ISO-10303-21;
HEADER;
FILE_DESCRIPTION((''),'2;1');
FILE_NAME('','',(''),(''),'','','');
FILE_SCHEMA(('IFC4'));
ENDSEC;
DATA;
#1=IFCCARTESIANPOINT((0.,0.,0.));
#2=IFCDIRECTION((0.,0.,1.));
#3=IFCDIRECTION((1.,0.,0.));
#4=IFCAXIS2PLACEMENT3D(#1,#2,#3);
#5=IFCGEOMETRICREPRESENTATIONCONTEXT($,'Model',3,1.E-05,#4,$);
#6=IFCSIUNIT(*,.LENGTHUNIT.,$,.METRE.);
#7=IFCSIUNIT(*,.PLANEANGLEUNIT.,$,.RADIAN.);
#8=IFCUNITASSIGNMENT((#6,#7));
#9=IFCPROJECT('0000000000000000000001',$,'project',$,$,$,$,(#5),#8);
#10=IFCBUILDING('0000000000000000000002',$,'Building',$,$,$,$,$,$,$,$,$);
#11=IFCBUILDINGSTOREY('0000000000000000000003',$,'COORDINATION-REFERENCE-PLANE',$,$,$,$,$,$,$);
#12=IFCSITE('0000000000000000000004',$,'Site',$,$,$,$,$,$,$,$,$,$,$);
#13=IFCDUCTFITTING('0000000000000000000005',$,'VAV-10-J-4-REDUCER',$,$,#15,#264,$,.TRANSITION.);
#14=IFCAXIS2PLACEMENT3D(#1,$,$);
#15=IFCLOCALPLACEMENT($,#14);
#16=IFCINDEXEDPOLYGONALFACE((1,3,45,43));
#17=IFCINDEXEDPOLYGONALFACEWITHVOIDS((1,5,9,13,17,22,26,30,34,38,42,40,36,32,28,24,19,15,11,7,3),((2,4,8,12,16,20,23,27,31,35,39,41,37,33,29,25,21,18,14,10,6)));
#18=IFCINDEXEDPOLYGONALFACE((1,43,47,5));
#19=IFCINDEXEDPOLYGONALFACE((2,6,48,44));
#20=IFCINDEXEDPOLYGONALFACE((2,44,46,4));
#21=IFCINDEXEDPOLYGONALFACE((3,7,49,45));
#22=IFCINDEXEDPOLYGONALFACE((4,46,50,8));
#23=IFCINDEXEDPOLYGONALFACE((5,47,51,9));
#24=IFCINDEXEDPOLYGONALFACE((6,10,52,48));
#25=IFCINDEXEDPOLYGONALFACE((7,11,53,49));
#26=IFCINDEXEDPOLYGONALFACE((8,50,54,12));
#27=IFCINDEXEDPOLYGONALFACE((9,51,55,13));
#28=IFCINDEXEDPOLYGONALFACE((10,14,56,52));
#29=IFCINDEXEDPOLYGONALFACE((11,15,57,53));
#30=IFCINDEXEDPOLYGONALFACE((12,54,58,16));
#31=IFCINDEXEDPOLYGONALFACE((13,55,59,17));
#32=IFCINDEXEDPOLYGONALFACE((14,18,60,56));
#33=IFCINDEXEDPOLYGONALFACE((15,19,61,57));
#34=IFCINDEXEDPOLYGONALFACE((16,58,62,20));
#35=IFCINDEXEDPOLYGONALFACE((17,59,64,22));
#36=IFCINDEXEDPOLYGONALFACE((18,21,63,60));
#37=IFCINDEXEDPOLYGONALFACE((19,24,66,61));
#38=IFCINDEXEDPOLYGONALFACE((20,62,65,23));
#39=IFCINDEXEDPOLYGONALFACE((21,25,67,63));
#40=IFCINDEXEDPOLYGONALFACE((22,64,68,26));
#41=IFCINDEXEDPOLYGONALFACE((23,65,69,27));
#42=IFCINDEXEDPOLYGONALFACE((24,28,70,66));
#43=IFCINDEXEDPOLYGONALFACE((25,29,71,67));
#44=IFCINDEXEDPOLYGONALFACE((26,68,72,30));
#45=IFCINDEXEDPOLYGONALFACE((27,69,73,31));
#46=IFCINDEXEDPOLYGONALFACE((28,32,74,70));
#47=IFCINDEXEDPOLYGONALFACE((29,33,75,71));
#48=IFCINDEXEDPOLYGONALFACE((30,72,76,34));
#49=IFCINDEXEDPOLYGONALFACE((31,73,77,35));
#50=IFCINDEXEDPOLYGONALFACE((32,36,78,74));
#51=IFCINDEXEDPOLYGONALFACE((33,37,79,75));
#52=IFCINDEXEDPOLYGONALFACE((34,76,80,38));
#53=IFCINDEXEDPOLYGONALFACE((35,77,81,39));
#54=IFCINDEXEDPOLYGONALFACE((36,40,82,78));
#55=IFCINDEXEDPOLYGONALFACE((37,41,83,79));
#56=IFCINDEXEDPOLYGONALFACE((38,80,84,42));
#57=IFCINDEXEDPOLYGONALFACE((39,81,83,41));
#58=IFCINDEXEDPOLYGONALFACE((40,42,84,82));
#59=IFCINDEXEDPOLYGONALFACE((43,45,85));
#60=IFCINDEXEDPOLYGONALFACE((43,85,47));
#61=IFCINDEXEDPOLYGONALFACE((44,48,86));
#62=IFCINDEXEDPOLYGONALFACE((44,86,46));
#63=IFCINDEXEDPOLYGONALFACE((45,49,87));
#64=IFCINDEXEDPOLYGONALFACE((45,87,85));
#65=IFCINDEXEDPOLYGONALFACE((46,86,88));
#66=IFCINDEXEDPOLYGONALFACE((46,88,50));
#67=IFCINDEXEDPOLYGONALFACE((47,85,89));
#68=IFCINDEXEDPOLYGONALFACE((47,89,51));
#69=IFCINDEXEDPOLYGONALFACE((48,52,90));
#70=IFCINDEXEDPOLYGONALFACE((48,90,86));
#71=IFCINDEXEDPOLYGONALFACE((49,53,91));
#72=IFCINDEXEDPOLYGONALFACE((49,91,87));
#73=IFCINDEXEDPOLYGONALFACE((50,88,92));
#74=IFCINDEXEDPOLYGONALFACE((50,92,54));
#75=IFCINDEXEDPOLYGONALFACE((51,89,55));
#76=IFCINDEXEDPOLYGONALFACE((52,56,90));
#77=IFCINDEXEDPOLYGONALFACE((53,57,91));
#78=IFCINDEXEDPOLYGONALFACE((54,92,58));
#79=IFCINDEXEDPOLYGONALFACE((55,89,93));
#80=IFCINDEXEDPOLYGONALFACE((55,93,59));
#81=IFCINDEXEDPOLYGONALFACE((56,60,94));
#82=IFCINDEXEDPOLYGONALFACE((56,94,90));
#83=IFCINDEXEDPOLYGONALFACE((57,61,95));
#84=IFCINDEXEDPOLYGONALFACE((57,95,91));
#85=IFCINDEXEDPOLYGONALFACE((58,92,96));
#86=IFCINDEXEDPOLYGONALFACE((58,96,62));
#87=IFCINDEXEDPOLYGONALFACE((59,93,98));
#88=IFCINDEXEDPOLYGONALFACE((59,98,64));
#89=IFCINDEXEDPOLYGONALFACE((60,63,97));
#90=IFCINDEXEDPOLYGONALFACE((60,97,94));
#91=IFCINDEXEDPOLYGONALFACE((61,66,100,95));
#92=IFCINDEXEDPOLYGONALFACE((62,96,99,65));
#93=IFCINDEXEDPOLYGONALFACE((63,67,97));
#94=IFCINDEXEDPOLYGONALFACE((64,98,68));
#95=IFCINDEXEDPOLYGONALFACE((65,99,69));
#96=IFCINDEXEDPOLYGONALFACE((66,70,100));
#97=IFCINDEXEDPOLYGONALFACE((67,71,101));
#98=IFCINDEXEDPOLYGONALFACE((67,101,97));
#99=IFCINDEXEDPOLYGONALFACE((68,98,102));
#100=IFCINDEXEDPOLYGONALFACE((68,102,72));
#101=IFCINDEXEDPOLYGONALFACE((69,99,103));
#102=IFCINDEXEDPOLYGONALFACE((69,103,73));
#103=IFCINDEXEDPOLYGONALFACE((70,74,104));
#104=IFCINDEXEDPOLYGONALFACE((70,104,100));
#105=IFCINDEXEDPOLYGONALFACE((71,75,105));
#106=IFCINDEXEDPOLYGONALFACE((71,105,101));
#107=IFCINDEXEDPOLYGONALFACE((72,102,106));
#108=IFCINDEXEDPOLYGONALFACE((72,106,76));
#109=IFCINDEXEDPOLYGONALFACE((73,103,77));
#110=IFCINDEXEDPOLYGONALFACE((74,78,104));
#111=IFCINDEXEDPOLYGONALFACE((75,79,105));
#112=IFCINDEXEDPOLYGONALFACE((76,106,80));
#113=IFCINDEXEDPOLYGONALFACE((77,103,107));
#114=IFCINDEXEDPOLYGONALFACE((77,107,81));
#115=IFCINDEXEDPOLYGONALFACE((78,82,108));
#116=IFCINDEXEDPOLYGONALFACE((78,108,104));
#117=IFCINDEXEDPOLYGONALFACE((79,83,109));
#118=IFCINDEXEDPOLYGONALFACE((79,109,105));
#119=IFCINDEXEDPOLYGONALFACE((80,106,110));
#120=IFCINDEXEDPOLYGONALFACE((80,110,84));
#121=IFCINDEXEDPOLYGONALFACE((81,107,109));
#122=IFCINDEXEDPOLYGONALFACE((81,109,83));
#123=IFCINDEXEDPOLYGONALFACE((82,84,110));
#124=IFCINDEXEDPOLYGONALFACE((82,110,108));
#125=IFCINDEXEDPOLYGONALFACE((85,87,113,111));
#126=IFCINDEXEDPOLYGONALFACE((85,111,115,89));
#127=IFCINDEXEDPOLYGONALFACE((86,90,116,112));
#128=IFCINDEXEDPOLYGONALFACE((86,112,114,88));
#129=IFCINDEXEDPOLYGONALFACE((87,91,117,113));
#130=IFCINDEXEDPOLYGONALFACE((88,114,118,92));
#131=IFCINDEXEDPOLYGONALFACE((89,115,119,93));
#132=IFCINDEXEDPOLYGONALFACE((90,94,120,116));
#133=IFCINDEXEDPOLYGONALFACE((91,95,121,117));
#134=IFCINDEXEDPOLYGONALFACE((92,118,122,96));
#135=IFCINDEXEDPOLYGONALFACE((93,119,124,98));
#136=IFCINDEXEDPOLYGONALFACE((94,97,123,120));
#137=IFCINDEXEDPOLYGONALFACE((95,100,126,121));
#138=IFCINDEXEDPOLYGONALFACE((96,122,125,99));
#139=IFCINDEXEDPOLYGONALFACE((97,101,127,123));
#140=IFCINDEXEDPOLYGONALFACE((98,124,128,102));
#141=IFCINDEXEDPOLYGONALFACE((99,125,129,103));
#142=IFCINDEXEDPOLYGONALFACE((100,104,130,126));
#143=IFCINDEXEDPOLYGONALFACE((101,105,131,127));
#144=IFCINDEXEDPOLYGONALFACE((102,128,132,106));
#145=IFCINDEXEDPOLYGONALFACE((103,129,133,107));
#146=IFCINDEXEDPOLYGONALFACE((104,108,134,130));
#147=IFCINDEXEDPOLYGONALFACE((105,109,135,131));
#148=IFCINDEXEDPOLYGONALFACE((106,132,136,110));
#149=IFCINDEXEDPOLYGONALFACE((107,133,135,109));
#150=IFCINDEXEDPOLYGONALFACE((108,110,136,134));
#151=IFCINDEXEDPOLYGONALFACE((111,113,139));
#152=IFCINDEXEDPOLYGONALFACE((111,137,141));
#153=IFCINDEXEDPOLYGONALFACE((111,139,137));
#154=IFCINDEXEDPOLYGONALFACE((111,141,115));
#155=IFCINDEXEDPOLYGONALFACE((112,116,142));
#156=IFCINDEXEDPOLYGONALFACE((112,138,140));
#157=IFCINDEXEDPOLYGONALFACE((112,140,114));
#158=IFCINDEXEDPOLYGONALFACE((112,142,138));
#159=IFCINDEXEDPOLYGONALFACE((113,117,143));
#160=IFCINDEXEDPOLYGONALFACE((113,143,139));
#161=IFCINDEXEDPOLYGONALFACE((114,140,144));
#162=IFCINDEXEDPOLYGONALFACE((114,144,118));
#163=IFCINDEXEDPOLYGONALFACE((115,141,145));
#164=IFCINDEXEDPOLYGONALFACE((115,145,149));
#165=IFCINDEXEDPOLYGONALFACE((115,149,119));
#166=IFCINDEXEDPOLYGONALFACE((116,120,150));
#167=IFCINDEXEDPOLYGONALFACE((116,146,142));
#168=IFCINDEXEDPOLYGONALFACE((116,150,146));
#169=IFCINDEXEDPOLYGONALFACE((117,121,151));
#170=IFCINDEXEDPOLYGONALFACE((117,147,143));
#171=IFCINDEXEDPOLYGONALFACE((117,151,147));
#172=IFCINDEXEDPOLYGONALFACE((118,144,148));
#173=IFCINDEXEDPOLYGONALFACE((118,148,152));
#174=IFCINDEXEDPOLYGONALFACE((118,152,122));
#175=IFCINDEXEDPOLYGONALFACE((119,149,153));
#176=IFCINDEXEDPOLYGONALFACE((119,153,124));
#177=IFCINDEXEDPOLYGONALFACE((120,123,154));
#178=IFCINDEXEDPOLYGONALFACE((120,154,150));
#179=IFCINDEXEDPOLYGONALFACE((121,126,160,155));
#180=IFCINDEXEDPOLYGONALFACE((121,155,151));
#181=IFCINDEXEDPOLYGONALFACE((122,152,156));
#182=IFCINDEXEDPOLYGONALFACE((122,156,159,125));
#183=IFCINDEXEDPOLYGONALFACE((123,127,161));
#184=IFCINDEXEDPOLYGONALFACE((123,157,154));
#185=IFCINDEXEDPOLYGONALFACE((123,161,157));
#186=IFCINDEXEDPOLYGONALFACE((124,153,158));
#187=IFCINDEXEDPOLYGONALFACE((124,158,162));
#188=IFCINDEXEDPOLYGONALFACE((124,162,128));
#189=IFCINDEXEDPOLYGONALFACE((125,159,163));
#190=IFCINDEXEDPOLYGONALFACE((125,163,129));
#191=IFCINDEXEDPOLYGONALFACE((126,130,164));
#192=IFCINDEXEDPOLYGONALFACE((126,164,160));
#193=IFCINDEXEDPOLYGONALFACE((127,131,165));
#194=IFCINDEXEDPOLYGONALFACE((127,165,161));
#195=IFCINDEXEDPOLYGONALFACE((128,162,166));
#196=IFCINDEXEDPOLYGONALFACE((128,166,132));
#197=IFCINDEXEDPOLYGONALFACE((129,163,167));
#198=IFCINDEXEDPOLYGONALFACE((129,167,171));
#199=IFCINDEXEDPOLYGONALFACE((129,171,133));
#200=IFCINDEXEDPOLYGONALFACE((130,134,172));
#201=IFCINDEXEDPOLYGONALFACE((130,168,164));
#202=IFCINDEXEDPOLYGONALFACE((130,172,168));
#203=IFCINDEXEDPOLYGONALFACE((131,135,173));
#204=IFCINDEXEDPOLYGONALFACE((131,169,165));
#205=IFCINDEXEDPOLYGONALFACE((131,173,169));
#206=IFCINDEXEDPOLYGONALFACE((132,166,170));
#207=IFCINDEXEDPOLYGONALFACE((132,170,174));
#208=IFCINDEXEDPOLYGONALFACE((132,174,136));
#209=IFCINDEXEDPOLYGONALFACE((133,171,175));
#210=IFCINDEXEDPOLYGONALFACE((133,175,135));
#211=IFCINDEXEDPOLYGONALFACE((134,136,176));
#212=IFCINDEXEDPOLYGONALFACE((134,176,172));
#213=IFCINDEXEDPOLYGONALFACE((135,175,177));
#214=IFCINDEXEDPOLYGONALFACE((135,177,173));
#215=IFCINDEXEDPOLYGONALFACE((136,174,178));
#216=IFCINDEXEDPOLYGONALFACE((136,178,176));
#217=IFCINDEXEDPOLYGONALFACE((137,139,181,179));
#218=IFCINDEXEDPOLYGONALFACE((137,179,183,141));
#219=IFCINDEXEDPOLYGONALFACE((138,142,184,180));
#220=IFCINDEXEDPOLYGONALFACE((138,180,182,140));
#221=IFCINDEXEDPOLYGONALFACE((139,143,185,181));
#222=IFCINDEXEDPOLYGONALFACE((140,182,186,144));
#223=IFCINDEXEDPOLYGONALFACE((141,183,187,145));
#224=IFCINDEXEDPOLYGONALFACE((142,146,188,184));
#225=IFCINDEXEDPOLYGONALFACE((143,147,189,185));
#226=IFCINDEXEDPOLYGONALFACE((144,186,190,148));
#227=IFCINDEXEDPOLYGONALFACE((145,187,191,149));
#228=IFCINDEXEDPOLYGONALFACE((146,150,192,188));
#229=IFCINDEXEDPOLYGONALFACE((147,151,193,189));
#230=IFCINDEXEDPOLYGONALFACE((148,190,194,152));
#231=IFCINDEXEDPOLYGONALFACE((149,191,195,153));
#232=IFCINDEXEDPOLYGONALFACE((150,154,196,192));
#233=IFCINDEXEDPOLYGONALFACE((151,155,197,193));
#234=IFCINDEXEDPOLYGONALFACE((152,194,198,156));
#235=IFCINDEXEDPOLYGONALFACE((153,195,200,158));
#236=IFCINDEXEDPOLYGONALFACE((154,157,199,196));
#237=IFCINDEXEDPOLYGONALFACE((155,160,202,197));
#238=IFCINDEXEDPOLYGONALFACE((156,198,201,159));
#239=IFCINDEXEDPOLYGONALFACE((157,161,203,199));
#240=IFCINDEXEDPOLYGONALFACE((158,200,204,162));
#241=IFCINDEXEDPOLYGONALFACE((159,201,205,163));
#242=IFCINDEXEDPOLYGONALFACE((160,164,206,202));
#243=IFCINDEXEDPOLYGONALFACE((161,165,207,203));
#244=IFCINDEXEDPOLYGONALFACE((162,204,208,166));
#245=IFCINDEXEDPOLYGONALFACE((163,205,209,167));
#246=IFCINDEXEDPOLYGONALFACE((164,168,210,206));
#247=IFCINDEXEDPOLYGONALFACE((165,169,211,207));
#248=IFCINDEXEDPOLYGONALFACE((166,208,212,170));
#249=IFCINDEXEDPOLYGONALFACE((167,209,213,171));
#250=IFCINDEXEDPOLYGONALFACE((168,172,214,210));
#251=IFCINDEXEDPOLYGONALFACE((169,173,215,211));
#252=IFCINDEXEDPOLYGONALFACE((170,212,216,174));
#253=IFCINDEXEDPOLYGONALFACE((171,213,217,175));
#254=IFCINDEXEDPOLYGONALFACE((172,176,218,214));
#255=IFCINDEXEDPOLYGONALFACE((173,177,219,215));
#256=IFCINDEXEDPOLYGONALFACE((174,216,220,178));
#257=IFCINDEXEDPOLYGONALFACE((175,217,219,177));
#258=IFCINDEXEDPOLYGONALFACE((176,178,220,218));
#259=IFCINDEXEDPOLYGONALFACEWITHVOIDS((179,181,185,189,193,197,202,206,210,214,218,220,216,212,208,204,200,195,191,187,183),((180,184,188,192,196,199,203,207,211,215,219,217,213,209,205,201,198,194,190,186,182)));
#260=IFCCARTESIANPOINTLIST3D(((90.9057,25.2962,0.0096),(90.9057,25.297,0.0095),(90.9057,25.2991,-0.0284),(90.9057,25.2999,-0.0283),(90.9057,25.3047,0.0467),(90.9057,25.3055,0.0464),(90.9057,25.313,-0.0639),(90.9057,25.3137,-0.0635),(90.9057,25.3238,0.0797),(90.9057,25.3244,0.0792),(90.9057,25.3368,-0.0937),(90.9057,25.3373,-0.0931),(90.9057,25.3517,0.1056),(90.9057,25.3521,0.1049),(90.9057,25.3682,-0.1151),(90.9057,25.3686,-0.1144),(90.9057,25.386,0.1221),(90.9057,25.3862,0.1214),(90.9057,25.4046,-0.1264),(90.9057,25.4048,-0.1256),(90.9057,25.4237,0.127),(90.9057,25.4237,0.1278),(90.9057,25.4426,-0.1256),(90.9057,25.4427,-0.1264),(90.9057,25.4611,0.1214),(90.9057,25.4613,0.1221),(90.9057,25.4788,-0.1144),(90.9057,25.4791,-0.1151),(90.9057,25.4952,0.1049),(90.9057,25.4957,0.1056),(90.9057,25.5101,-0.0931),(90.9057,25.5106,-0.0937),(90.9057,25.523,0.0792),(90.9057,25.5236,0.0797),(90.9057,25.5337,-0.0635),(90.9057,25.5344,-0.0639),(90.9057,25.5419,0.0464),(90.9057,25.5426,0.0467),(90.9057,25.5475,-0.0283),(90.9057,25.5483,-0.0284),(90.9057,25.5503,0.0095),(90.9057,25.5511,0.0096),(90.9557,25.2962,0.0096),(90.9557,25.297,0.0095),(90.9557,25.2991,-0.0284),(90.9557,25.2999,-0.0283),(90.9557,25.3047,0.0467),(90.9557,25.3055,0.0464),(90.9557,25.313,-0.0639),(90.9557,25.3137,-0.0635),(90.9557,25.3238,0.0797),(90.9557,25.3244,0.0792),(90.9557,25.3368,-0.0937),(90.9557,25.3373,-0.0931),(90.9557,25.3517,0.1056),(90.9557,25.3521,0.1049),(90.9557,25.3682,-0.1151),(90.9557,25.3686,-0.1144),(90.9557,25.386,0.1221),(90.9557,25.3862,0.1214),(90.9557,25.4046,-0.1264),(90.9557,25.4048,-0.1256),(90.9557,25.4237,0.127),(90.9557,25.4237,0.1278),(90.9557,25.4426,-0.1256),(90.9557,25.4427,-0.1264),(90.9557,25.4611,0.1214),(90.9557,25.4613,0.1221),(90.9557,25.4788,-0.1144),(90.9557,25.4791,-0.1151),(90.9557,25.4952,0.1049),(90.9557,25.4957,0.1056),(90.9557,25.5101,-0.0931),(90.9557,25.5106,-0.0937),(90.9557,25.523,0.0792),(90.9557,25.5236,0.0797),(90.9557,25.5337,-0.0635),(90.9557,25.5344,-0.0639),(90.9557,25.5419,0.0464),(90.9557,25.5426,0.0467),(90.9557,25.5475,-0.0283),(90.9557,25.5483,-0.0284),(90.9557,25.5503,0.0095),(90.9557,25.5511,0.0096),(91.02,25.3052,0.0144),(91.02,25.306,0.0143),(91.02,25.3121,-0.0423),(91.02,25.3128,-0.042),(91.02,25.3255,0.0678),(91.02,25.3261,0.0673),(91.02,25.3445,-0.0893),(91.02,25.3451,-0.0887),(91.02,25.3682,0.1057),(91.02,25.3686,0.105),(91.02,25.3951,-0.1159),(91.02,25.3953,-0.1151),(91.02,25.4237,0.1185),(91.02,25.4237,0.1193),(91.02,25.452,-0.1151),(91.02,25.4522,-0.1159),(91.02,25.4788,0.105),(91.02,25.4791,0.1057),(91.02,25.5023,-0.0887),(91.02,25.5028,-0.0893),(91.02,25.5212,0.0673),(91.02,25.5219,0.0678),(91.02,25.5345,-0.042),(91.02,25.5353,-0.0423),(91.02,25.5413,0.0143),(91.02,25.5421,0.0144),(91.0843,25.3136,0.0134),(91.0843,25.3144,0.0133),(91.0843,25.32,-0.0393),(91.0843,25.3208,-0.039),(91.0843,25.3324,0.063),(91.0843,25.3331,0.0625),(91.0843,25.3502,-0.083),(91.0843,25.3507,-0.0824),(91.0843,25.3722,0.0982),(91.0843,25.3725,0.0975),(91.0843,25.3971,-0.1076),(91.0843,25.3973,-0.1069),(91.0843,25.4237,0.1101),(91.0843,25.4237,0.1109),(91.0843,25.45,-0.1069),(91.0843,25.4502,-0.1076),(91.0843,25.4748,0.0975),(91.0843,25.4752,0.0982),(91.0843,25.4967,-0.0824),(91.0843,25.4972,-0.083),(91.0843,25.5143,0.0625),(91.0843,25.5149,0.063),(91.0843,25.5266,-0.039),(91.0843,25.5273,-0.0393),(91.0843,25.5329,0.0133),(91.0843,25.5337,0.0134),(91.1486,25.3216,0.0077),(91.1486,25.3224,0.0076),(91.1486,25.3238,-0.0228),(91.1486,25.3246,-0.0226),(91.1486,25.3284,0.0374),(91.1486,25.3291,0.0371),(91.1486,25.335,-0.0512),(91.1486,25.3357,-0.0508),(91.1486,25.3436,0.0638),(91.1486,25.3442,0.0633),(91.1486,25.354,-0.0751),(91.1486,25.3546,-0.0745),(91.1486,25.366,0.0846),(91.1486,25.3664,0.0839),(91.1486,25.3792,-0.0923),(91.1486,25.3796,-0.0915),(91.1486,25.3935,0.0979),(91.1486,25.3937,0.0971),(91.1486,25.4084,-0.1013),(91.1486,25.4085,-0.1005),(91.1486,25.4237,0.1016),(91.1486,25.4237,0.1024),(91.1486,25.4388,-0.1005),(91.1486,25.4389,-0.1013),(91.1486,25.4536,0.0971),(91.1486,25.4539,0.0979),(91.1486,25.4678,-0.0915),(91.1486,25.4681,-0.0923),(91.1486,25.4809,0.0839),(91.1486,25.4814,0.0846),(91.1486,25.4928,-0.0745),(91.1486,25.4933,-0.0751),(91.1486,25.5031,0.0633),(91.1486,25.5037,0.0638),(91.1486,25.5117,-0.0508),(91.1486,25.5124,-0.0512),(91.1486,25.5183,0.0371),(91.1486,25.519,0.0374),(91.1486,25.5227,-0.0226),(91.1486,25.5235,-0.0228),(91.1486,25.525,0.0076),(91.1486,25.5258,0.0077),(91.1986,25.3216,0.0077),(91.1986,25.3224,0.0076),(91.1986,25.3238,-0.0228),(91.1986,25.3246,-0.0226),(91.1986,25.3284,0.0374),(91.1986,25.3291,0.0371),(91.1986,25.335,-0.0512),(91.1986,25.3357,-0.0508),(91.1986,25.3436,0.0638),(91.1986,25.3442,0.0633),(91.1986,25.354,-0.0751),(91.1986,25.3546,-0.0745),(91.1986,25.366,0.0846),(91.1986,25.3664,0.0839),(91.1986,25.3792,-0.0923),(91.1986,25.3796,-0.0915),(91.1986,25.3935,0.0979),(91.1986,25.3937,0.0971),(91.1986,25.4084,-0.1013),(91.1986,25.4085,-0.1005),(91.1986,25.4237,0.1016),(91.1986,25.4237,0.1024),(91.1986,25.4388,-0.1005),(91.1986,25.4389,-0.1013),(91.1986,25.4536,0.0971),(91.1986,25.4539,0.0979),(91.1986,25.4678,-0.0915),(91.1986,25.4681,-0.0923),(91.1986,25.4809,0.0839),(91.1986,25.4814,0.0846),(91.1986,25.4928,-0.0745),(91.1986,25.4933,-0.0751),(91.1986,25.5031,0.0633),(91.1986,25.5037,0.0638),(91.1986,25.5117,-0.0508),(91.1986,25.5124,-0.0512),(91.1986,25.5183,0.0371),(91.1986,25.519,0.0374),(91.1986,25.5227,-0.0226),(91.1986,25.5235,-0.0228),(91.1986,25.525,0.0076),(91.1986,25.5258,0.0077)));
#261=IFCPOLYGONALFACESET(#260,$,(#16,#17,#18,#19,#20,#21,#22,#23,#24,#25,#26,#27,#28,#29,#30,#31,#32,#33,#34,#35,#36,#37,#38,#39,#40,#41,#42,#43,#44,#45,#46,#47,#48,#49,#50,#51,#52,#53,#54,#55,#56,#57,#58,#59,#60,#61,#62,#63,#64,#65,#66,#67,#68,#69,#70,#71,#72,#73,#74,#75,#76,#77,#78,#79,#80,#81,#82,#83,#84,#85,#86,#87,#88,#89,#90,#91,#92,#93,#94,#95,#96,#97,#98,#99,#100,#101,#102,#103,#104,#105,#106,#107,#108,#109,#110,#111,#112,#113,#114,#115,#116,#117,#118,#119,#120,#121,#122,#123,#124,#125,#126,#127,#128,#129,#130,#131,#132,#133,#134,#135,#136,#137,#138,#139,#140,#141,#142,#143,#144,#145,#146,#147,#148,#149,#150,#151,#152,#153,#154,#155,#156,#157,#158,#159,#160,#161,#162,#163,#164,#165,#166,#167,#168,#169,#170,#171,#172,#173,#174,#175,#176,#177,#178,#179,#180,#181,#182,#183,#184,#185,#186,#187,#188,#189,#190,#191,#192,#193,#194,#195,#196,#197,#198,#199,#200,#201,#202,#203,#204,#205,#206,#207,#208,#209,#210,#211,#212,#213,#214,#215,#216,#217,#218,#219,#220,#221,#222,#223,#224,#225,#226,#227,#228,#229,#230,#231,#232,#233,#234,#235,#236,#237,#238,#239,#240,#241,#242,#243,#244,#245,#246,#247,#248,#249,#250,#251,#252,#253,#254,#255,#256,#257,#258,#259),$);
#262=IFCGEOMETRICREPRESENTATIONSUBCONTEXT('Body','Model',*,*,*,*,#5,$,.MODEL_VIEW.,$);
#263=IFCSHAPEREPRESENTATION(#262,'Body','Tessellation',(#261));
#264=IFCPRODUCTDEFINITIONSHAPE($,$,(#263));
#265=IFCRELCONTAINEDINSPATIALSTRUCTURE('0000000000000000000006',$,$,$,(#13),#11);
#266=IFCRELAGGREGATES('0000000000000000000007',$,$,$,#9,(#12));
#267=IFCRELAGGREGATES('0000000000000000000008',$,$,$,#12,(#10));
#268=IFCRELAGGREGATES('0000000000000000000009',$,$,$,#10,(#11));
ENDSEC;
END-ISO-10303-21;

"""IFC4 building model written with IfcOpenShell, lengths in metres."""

from ifc_helpers import new_model, entity, si_unit, frame, origin_with_axes, place, context, subcontext, project, spatial, element, save


model = new_model("IFC4")

# Units and contexts
model_context = context("Model", 3, precision=1e-05, world=origin_with_axes())
body_context_1 = subcontext(model_context, "Body", "Model", "MODEL_VIEW")
ifc_project = project(units=[si_unit("LENGTHUNIT", "METRE"), si_unit("PLANEANGLEUNIT", "RADIAN")], contexts=[model_context])

# Site, building, storey
site = spatial("IfcSite", under=ifc_project, Name="Site")
building = spatial("IfcBuilding", under=site, Name="Building")
storey = spatial("IfcBuildingStorey", under=building, Name="COORDINATION-REFERENCE-PLANE")

# Duct fitting
for number, where, z_axis, x_axis, name in (
    (1, (90.9057, 25.4237, 0.0), (0.0, 1.0, 0.0), (0.0, 0.0, 1.0), "VAV-10-J-4-REDUCER"),
):
    element("IfcDuctFitting", number, at=place(None, frame(where, z_axis=z_axis, x_axis=x_axis)), inside=storey, Name=name, PredefinedType="TRANSITION", context=body_context_1, shape_type="SweptSolid", body=[
        entity("IfcRevolvedAreaSolid", entity("IfcArbitraryClosedProfileDef", "AREA", None, entity("IfcPolyline", [entity("IfcCartesianPoint", [0.1278, 0.0]), entity("IfcCartesianPoint", [0.1278, 0.05]), entity("IfcCartesianPoint", [0.1024, 0.2429]), entity("IfcCartesianPoint", [0.1024, 0.2929]), entity("IfcCartesianPoint", [0.1016, 0.2929]), entity("IfcCartesianPoint", [0.1016, 0.2429]), entity("IfcCartesianPoint", [0.127, 0.05]), entity("IfcCartesianPoint", [0.127, 0.0]), entity("IfcCartesianPoint", [0.1278, 0.0])])), entity("IfcAxis2Placement3D", entity("IfcCartesianPoint", [0.0, 0.0, 0.0])), entity("IfcAxis1Placement", entity("IfcCartesianPoint", [0.0, 0.0, 0.0]), entity("IfcDirection", [0.0, 1.0, 0.0])), 6.283185),
    ])

save(model, "model.ifc")
